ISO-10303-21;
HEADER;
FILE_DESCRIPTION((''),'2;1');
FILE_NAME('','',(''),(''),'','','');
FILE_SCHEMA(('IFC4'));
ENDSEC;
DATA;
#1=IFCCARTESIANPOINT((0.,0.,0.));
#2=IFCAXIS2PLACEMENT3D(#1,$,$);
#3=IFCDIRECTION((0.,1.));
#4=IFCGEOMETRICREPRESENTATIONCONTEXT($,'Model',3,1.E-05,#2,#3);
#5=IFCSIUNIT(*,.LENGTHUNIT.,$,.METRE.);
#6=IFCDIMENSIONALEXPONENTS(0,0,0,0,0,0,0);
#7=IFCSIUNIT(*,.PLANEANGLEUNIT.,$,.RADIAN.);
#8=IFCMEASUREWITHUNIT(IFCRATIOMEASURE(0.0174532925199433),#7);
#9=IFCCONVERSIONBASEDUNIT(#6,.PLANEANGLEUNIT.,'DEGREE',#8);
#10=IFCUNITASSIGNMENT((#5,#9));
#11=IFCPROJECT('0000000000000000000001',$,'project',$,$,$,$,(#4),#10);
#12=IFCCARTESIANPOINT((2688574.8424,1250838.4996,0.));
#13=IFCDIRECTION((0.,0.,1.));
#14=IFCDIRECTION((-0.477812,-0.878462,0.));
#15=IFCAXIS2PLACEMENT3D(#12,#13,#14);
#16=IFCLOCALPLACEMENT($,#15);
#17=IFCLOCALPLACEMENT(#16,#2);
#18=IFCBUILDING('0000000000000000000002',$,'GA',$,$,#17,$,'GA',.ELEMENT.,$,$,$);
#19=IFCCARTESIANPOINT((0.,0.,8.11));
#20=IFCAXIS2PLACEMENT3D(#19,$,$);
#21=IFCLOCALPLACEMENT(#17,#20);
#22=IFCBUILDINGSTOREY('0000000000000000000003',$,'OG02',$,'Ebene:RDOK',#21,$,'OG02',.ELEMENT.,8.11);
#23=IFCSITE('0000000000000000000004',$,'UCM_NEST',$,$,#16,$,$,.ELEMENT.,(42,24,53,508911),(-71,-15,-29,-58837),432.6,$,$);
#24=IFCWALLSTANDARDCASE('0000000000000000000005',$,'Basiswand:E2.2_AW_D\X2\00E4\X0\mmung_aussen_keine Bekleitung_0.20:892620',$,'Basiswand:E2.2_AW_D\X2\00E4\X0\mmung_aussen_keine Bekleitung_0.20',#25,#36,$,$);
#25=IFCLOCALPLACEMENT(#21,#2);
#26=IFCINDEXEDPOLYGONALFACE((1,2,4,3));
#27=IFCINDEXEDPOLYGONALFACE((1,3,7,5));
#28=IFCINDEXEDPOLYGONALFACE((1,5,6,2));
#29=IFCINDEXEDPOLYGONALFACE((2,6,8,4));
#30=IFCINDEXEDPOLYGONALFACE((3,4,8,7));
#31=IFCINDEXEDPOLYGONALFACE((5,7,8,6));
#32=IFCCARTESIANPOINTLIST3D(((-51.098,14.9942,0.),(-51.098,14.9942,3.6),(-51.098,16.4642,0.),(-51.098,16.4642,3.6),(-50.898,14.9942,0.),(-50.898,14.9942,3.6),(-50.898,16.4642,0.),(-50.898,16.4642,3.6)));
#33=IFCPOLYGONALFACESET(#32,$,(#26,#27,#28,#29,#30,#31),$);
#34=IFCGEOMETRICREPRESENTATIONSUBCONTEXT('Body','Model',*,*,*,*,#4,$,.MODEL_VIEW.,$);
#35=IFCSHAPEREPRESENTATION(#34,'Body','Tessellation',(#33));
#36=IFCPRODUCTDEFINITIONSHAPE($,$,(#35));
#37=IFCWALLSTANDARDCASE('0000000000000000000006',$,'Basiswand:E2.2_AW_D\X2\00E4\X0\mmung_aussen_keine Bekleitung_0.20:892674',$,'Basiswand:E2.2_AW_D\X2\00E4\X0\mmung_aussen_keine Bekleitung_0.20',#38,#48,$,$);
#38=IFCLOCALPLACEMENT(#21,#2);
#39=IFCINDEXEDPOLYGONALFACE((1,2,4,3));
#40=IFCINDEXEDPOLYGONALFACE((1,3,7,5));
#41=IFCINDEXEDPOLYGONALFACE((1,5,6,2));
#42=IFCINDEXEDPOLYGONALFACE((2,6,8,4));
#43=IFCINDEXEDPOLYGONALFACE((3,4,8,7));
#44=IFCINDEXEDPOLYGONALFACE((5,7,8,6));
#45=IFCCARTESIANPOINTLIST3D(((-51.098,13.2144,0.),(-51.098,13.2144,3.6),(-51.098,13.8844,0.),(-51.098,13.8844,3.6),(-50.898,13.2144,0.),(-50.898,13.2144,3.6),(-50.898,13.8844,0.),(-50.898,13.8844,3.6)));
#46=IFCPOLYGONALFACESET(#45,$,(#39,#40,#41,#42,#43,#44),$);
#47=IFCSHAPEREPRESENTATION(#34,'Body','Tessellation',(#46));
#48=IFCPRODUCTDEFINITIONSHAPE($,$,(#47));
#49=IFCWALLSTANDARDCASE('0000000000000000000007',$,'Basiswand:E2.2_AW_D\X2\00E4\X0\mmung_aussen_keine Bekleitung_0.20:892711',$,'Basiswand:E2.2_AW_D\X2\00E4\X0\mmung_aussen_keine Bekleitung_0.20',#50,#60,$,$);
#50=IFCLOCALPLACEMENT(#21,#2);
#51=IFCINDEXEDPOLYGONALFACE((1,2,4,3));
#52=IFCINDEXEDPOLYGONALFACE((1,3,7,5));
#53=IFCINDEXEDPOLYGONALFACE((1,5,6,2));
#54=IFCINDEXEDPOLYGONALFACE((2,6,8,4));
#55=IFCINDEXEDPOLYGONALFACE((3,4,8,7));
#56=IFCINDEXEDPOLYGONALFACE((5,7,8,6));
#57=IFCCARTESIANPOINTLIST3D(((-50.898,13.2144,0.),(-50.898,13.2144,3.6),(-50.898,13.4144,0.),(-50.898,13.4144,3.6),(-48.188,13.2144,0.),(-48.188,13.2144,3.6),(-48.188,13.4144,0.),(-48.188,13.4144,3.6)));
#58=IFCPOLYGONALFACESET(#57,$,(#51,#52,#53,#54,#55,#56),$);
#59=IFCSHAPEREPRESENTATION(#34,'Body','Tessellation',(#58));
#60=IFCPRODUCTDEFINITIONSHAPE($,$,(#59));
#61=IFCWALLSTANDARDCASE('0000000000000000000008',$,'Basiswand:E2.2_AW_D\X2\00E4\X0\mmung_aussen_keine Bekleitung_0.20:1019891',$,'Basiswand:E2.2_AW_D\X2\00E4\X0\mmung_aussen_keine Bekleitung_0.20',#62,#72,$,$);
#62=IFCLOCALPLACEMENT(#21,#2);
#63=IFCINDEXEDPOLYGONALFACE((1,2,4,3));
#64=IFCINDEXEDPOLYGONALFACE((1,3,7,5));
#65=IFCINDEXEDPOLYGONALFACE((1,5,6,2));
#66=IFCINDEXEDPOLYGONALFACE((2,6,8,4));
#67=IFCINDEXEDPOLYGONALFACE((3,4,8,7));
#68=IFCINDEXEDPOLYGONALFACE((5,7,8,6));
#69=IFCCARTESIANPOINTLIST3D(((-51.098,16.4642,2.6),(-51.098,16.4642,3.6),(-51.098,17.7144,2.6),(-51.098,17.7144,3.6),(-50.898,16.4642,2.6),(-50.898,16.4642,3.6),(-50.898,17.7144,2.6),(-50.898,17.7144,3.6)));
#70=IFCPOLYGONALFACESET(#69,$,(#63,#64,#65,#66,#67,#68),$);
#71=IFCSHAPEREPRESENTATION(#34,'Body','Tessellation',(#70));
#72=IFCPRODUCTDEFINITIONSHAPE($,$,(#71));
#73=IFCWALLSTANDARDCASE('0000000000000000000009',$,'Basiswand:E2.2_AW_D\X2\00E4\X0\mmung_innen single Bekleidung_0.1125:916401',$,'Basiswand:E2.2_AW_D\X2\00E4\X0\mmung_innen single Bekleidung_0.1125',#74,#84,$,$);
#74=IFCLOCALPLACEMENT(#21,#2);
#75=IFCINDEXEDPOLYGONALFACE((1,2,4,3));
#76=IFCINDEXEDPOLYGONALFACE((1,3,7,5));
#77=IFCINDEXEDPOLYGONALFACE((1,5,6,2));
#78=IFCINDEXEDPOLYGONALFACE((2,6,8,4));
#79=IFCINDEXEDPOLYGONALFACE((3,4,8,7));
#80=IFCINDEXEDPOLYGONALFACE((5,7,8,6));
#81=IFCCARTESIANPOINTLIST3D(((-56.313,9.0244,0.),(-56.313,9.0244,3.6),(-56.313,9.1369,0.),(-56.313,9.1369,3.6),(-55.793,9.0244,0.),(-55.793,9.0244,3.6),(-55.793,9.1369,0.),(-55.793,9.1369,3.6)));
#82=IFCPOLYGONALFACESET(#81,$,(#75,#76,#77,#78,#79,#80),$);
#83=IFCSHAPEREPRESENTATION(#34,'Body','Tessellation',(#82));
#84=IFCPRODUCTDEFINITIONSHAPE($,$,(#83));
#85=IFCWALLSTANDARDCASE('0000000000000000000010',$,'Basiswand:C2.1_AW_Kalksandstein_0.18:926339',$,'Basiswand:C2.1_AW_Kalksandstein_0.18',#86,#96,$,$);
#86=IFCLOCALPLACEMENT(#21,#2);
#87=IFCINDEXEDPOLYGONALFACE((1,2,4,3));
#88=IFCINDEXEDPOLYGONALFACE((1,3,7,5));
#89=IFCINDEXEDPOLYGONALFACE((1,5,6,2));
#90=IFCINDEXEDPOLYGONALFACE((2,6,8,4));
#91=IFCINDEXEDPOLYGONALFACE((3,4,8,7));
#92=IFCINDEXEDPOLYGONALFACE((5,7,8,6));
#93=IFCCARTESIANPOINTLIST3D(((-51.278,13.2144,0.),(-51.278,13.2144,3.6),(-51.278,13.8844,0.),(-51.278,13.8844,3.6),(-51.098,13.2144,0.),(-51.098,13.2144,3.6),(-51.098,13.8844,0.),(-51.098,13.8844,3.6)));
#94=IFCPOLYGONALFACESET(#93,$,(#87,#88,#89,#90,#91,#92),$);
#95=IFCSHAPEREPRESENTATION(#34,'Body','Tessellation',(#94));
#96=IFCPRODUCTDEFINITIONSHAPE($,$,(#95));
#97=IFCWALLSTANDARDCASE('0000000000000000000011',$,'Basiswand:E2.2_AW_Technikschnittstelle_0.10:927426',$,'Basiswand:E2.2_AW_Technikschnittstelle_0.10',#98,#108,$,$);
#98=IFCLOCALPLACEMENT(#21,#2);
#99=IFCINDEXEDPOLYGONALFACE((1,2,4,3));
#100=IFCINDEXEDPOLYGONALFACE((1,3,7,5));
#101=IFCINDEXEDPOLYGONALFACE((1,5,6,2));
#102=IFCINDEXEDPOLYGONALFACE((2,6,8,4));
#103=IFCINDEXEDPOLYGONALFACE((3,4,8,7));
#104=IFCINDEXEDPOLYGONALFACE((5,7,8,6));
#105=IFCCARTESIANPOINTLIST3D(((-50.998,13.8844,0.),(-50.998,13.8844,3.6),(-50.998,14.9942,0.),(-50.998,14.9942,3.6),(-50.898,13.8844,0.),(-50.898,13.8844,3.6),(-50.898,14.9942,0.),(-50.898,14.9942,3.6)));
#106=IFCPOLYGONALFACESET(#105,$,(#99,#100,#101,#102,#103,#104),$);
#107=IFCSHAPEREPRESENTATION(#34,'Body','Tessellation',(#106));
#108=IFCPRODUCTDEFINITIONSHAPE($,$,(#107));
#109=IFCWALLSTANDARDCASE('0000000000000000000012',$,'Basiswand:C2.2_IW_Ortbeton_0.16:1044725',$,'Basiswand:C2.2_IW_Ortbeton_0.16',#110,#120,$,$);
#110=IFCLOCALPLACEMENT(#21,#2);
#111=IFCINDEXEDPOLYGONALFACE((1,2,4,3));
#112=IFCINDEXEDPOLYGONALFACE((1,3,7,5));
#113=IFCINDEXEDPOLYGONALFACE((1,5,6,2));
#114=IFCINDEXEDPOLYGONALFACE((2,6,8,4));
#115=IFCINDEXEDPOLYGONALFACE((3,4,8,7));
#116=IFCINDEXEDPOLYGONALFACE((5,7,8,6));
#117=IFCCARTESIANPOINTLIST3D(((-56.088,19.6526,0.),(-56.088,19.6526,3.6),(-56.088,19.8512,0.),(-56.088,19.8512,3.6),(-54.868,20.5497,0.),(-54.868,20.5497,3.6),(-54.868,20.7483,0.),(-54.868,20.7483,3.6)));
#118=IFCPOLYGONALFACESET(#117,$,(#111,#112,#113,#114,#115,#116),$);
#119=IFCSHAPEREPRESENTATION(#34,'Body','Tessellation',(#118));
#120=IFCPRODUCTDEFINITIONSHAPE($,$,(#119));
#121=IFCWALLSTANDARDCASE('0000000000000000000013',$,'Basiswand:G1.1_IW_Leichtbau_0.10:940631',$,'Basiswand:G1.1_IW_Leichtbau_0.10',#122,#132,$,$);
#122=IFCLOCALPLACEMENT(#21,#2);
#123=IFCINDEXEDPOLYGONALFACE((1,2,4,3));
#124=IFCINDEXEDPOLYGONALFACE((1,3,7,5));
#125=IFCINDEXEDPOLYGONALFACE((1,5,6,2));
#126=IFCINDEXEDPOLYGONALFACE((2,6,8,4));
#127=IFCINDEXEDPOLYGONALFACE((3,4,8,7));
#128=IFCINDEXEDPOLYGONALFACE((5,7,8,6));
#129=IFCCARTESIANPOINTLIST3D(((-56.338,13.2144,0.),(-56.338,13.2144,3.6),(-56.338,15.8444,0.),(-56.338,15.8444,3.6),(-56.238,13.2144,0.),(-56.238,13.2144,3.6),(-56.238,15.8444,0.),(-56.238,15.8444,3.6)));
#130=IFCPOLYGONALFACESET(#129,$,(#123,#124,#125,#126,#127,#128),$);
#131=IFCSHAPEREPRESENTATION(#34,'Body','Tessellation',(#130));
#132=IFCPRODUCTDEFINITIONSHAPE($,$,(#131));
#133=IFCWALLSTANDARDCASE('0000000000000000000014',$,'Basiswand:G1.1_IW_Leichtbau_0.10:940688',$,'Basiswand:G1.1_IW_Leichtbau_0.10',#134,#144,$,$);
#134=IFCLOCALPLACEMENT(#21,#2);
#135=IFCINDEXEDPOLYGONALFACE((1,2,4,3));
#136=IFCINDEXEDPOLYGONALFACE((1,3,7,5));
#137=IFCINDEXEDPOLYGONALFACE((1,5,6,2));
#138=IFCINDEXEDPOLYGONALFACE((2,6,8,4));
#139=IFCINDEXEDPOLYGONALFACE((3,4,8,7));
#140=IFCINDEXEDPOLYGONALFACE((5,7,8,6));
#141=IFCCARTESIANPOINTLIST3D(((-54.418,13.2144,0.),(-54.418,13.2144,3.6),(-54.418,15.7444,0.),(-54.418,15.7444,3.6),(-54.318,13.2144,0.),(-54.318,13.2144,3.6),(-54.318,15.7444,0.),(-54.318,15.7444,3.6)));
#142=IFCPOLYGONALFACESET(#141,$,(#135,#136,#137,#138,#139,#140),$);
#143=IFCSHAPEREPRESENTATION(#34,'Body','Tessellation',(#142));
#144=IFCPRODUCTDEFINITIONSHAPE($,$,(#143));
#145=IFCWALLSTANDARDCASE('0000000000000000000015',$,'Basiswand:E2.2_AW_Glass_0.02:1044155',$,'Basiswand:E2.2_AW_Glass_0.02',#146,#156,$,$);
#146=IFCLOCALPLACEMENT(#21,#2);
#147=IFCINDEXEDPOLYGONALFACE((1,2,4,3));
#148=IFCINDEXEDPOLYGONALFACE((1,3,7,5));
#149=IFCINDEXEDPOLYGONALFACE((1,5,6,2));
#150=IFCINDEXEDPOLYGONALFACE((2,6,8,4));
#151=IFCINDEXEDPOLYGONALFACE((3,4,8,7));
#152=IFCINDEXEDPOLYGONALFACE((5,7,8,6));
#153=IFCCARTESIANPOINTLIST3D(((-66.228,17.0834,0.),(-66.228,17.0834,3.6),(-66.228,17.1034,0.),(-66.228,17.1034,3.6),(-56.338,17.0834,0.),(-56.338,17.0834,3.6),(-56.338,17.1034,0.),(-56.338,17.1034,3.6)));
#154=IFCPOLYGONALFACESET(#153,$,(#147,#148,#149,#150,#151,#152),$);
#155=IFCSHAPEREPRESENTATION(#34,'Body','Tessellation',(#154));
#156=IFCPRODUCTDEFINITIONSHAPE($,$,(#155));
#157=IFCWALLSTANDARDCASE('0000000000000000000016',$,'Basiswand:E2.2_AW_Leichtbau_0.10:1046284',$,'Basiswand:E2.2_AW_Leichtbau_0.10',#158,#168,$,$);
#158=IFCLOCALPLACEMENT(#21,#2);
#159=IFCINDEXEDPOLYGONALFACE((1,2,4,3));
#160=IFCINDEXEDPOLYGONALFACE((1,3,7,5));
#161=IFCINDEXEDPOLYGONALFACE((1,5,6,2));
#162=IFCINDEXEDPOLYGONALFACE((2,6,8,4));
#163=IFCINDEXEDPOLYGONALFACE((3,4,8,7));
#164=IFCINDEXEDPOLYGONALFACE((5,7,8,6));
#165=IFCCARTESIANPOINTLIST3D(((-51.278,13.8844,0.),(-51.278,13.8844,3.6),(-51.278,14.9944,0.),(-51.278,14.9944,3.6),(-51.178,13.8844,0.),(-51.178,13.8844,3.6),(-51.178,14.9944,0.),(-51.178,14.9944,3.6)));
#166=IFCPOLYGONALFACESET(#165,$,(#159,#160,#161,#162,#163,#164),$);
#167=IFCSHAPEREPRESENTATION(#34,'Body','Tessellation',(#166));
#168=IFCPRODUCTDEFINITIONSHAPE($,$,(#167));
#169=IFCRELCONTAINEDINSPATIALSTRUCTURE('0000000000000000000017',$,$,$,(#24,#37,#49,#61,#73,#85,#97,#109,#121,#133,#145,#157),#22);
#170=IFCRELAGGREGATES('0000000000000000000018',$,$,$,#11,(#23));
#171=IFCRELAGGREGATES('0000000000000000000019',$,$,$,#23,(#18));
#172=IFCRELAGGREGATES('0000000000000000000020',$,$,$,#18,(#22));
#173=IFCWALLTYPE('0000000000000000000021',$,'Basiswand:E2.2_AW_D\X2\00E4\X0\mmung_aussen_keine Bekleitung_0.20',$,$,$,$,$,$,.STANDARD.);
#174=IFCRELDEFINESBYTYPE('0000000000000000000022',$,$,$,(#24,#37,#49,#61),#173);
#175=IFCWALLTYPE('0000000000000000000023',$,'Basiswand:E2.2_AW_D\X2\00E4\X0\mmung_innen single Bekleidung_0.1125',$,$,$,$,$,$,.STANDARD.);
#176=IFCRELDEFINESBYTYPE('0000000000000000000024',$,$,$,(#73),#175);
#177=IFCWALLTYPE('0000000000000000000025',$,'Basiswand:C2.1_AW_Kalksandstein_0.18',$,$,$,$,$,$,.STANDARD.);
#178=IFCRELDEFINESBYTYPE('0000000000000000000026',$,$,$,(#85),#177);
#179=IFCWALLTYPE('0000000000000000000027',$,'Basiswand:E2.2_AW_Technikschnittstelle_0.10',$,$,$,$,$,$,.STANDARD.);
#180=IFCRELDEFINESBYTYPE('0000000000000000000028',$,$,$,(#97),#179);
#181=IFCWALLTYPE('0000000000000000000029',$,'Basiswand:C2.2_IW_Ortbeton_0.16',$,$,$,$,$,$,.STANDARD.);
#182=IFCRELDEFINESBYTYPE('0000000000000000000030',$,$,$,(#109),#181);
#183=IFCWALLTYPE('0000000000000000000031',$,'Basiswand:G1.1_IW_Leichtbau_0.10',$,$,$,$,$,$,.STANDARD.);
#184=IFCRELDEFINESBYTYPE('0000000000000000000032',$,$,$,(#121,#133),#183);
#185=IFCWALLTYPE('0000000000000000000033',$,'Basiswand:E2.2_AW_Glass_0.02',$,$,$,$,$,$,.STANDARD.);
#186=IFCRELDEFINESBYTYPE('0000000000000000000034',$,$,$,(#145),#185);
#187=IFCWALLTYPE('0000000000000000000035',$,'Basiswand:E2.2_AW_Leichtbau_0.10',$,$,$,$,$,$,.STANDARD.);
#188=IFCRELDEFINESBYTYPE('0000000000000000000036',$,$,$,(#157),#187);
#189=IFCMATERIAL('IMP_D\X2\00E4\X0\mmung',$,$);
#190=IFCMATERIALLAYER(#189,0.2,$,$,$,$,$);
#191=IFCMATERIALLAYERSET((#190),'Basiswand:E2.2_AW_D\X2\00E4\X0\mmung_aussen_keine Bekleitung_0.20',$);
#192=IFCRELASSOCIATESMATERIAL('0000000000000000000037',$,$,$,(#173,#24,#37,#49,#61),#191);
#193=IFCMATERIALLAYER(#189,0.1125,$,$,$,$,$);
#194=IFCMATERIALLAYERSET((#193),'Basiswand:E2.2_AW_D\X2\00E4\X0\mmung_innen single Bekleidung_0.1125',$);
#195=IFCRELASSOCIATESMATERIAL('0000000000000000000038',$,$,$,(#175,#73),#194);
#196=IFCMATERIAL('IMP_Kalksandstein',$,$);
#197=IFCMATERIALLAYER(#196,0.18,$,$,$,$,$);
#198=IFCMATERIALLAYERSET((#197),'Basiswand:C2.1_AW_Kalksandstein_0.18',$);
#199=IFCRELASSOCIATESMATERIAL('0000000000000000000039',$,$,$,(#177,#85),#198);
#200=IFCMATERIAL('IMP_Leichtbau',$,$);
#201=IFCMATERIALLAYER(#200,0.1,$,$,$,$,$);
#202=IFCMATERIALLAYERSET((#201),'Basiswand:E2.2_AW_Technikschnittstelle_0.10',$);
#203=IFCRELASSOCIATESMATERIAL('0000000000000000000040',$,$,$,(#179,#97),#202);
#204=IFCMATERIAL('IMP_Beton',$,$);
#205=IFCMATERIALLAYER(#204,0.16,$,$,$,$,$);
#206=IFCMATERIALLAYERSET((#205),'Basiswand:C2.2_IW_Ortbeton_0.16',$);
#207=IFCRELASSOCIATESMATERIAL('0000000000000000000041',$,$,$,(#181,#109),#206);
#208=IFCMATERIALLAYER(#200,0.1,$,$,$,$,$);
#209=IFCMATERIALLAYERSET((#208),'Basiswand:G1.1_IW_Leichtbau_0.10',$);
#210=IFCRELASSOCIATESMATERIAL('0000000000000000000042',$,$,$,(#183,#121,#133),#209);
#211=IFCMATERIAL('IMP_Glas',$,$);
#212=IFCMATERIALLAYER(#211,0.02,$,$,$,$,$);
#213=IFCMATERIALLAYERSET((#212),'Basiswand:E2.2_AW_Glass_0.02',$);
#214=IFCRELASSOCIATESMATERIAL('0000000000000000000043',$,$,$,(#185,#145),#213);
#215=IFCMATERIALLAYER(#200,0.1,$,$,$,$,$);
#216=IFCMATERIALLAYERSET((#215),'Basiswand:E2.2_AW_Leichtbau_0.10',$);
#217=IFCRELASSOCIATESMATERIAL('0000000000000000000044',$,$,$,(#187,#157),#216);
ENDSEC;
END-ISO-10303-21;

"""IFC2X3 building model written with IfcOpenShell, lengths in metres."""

from ifc_helpers import new_model, entity, si_unit, converted_unit, direction, frame, frame_2d, origin, place, context, subcontext, project, spatial, polyline, rectangle, outline, extrude, material, layer, layer_set, layer_usage, type_object, element, save


model = new_model("IFC2X3")

# Units and contexts
model_context = context("Model", 3, precision=1e-05, world=origin(), true_north=direction((0.0, 1.0)))
body_context = subcontext(model_context, "Body", "Model", "MODEL_VIEW")
ifc_project = project(units=[si_unit("LENGTHUNIT", "METRE"), converted_unit("PLANEANGLEUNIT", "DEGREE", entity("IfcRatioMeasure", 0.0174532925199433), si_unit("PLANEANGLEUNIT", "RADIAN"), dimensions=[0, 0, 0, 0, 0, 0, 0])], contexts=[model_context])

# Site, building, storey
site_placement = place(None, frame((2688574.8424, 1250838.4996, 0.0), z_axis=(0.0, 0.0, 1.0), x_axis=(-0.477812, -0.878462, 0.0)))
site = spatial("IfcSite", under=ifc_project, at=site_placement, Name="UCM_NEST", CompositionType="ELEMENT", RefLatitude=(42, 24, 53, 508911), RefLongitude=(-71, -15, -29, -58837), RefElevation=432.6)
building_placement = place(site_placement, origin())
building = spatial("IfcBuilding", under=site, at=building_placement, Name="GA", LongName="GA", CompositionType="ELEMENT")
storey_placement = place(building_placement, frame((0.0, 0.0, 8.11)))
storey = spatial("IfcBuildingStorey", under=building, at=storey_placement, Name="OG02", ObjectType="Ebene:RDOK", LongName="OG02", CompositionType="ELEMENT", Elevation=8.11)

# Walls
ifc_material_1 = material(Name="IMP_Dämmung")
ifc_layer_1 = layer(ifc_material_1, 0.2)
ifc_layer_set_1 = layer_set([ifc_layer_1], Name="Basiswand:E2.2_AW_Dämmung_aussen_keine Bekleitung_0.20")
ifc_layer_usage_1 = layer_usage(ifc_layer_set_1, "AXIS2", "NEGATIVE", 0.1)
wall_type_1 = type_object("IfcWallType", Name="Basiswand:E2.2_AW_Dämmung_aussen_keine Bekleitung_0.20", PredefinedType="STANDARD", material=ifc_layer_set_1)
wall_1_placement = place(storey_placement, frame((-50.998, 16.4642, 0.0), z_axis=(0.0, 0.0, 1.0), x_axis=(0.0, -1.0, 0.0)))
element("IfcWallStandardCase", 1, at=wall_1_placement, inside=storey, type_object=wall_type_1, material=ifc_layer_usage_1, Name="Basiswand:E2.2_AW_Dämmung_aussen_keine Bekleitung_0.20:892620", ObjectType="Basiswand:E2.2_AW_Dämmung_aussen_keine Bekleitung_0.20", context=body_context, shape_type="SweptSolid", body=[
    extrude(rectangle(XDim=1.47, YDim=0.2, at=frame_2d((0.735, 0.0), x_axis=(-1.0, 0.0))), origin(), (0.0, 0.0, 1.0), 3.6),
])
ifc_layer_usage_2 = layer_usage(ifc_layer_set_1, "AXIS2", "NEGATIVE", 0.1)
wall_2_placement = place(storey_placement, frame((-50.998, 13.8844, 0.0), z_axis=(0.0, 0.0, 1.0), x_axis=(0.0, -1.0, 0.0)))
element("IfcWallStandardCase", 2, at=wall_2_placement, inside=storey, type_object=wall_type_1, material=ifc_layer_usage_2, Name="Basiswand:E2.2_AW_Dämmung_aussen_keine Bekleitung_0.20:892674", ObjectType="Basiswand:E2.2_AW_Dämmung_aussen_keine Bekleitung_0.20", context=body_context, shape_type="SweptSolid", body=[
    extrude(rectangle(XDim=0.67, YDim=0.2, at=frame_2d((0.335, 0.0), x_axis=(-1.0, 0.0))), origin(), (0.0, 0.0, 1.0), 3.6),
])
ifc_layer_usage_3 = layer_usage(ifc_layer_set_1, "AXIS2", "NEGATIVE", 0.1)
wall_3_placement = place(storey_placement, frame((-50.898, 13.3144, 0.0)))
element("IfcWallStandardCase", 3, at=wall_3_placement, inside=storey, type_object=wall_type_1, material=ifc_layer_usage_3, Name="Basiswand:E2.2_AW_Dämmung_aussen_keine Bekleitung_0.20:892711", ObjectType="Basiswand:E2.2_AW_Dämmung_aussen_keine Bekleitung_0.20", context=body_context, shape_type="SweptSolid", body=[
    extrude(rectangle(XDim=2.71, YDim=0.2, at=frame_2d((1.355, 0.0), x_axis=(-1.0, 0.0))), origin(), (0.0, 0.0, 1.0), 3.6),
])
ifc_layer_usage_4 = layer_usage(ifc_layer_set_1, "AXIS2", "NEGATIVE", 0.1)
wall_4_placement = place(storey_placement, frame((-50.998, 17.7144, 2.6), z_axis=(0.0, 0.0, 1.0), x_axis=(0.0, -1.0, 0.0)))
element("IfcWallStandardCase", 4, at=wall_4_placement, inside=storey, type_object=wall_type_1, material=ifc_layer_usage_4, Name="Basiswand:E2.2_AW_Dämmung_aussen_keine Bekleitung_0.20:1019891", ObjectType="Basiswand:E2.2_AW_Dämmung_aussen_keine Bekleitung_0.20", context=body_context, shape_type="SweptSolid", body=[
    extrude(rectangle(XDim=1.2502, YDim=0.2, at=frame_2d((0.6251, 0.0), x_axis=(-1.0, 0.0))), origin(), (0.0, 0.0, 1.0), 1.0),
])

# Shared definitions
ifc_material_2 = material(Name="IMP_Beton")

# Walls
ifc_layer_2 = layer(ifc_material_1, 0.1125)
ifc_layer_set_2 = layer_set([ifc_layer_2], Name="Basiswand:E2.2_AW_Dämmung_innen single Bekleidung_0.1125")
ifc_layer_usage_5 = layer_usage(ifc_layer_set_2, "AXIS2", "NEGATIVE", 0.0563)
wall_type_2 = type_object("IfcWallType", Name="Basiswand:E2.2_AW_Dämmung_innen single Bekleidung_0.1125", PredefinedType="STANDARD", material=ifc_layer_set_2)
wall_5_placement = place(storey_placement, frame((-56.313, 9.0807, 0.0)))
element("IfcWallStandardCase", 5, at=wall_5_placement, inside=storey, type_object=wall_type_2, material=ifc_layer_usage_5, Name="Basiswand:E2.2_AW_Dämmung_innen single Bekleidung_0.1125:916401", ObjectType="Basiswand:E2.2_AW_Dämmung_innen single Bekleidung_0.1125", context=body_context, shape_type="SweptSolid", body=[
    extrude(rectangle(XDim=0.52, YDim=0.1125, at=frame_2d((0.26, 0.0), x_axis=(-1.0, 0.0))), origin(), (0.0, 0.0, 1.0), 3.6),
])
ifc_material_3 = material(Name="IMP_Kalksandstein")
ifc_layer_3 = layer(ifc_material_3, 0.18)
ifc_layer_set_3 = layer_set([ifc_layer_3], Name="Basiswand:C2.1_AW_Kalksandstein_0.18")
ifc_layer_usage_6 = layer_usage(ifc_layer_set_3, "AXIS2", "NEGATIVE", 0.09)
wall_type_3 = type_object("IfcWallType", Name="Basiswand:C2.1_AW_Kalksandstein_0.18", PredefinedType="STANDARD", material=ifc_layer_set_3)
wall_6_placement = place(storey_placement, frame((-51.188, 13.8844, 0.0), z_axis=(0.0, 0.0, 1.0), x_axis=(0.0, -1.0, 0.0)))
element("IfcWallStandardCase", 6, at=wall_6_placement, inside=storey, type_object=wall_type_3, material=ifc_layer_usage_6, Name="Basiswand:C2.1_AW_Kalksandstein_0.18:926339", ObjectType="Basiswand:C2.1_AW_Kalksandstein_0.18", context=body_context, shape_type="SweptSolid", body=[
    extrude(rectangle(XDim=0.67, YDim=0.18, at=frame_2d((0.335, 0.0), x_axis=(-1.0, 0.0))), origin(), (0.0, 0.0, 1.0), 3.6),
])
ifc_material_4 = material(Name="IMP_Leichtbau")
ifc_layer_4 = layer(ifc_material_4, 0.1)
ifc_layer_set_4 = layer_set([ifc_layer_4], Name="Basiswand:E2.2_AW_Technikschnittstelle_0.10")
ifc_layer_usage_7 = layer_usage(ifc_layer_set_4, "AXIS2", "NEGATIVE", 0.05)
wall_type_4 = type_object("IfcWallType", Name="Basiswand:E2.2_AW_Technikschnittstelle_0.10", PredefinedType="STANDARD", material=ifc_layer_set_4)
wall_7_placement = place(storey_placement, frame((-50.948, 14.9942, 0.0), z_axis=(0.0, 0.0, 1.0), x_axis=(0.0, -1.0, 0.0)))
element("IfcWallStandardCase", 7, at=wall_7_placement, inside=storey, type_object=wall_type_4, material=ifc_layer_usage_7, Name="Basiswand:E2.2_AW_Technikschnittstelle_0.10:927426", ObjectType="Basiswand:E2.2_AW_Technikschnittstelle_0.10", context=body_context, shape_type="SweptSolid", body=[
    extrude(rectangle(XDim=1.1098, YDim=0.1, at=frame_2d((0.5549, 0.0), x_axis=(-1.0, 0.0))), origin(), (0.0, 0.0, 1.0), 3.6),
])
ifc_layer_5 = layer(ifc_material_2, 0.16)
ifc_layer_set_5 = layer_set([ifc_layer_5], Name="Basiswand:C2.2_IW_Ortbeton_0.16")
wall_type_5 = type_object("IfcWallType", Name="Basiswand:C2.2_IW_Ortbeton_0.16", PredefinedType="STANDARD", material=ifc_layer_set_5)
ifc_layer_usage_8 = layer_usage(ifc_layer_set_5, "AXIS2", "NEGATIVE", 0.08)
wall_8_placement = place(storey_placement, frame((-54.8206, 20.6838, 0.0), z_axis=(0.0, 0.0, 1.0), x_axis=(-0.805651, -0.59239, 0.0)))
element("IfcWallStandardCase", 8, at=wall_8_placement, inside=storey, type_object=wall_type_5, material=ifc_layer_usage_8, Name="Basiswand:C2.2_IW_Ortbeton_0.16:1044725", ObjectType="Basiswand:C2.2_IW_Ortbeton_0.16", context=body_context, shape_type="SweptSolid", body=[
    extrude(outline(polyline([(1.5143, -0.08), (1.632, 0.08), (0.1176, 0.08), (0.0, -0.08), (1.5143, -0.08)])), origin(), (0.0, 0.0, 1.0), 3.6),
])
ifc_layer_6 = layer(ifc_material_4, 0.1)
ifc_layer_set_6 = layer_set([ifc_layer_6], Name="Basiswand:G1.1_IW_Leichtbau_0.10")
ifc_layer_usage_9 = layer_usage(ifc_layer_set_6, "AXIS2", "NEGATIVE", 0.05)
wall_type_6 = type_object("IfcWallType", Name="Basiswand:G1.1_IW_Leichtbau_0.10", PredefinedType="STANDARD", material=ifc_layer_set_6)
wall_9_placement = place(storey_placement, frame((-56.288, 15.8444, 0.0), z_axis=(0.0, 0.0, 1.0), x_axis=(0.0, -1.0, 0.0)))
element("IfcWallStandardCase", 9, at=wall_9_placement, inside=storey, type_object=wall_type_6, material=ifc_layer_usage_9, Name="Basiswand:G1.1_IW_Leichtbau_0.10:940631", ObjectType="Basiswand:G1.1_IW_Leichtbau_0.10", context=body_context, shape_type="SweptSolid", body=[
    extrude(rectangle(XDim=2.63, YDim=0.1, at=frame_2d((1.315, 0.0), x_axis=(-1.0, 0.0))), origin(), (0.0, 0.0, 1.0), 3.6),
])
ifc_layer_usage_10 = layer_usage(ifc_layer_set_6, "AXIS2", "NEGATIVE", 0.05)
wall_10_placement = place(storey_placement, frame((-54.368, 13.2144, 0.0), z_axis=(0.0, 0.0, 1.0), x_axis=(0.0, 1.0, 0.0)))
element("IfcWallStandardCase", 10, at=wall_10_placement, inside=storey, type_object=wall_type_6, material=ifc_layer_usage_10, Name="Basiswand:G1.1_IW_Leichtbau_0.10:940688", ObjectType="Basiswand:G1.1_IW_Leichtbau_0.10", context=body_context, shape_type="SweptSolid", body=[
    extrude(rectangle(XDim=2.53, YDim=0.1, at=frame_2d((1.265, 0.0), x_axis=(-1.0, 0.0))), origin(), (0.0, 0.0, 1.0), 3.6),
])

# Walls
ifc_material_5 = material(Name="IMP_Glas")
ifc_layer_7 = layer(ifc_material_5, 0.02)
ifc_layer_set_7 = layer_set([ifc_layer_7], Name="Basiswand:E2.2_AW_Glass_0.02")
ifc_layer_usage_11 = layer_usage(ifc_layer_set_7, "AXIS2", "NEGATIVE", 0.01)
wall_type_7 = type_object("IfcWallType", Name="Basiswand:E2.2_AW_Glass_0.02", PredefinedType="STANDARD", material=ifc_layer_set_7)
wall_11_placement = place(storey_placement, frame((-56.338, 17.0934, 0.0), z_axis=(0.0, 0.0, 1.0), x_axis=(-1.0, 0.0, 0.0)))
element("IfcWallStandardCase", 11, at=wall_11_placement, inside=storey, type_object=wall_type_7, material=ifc_layer_usage_11, Name="Basiswand:E2.2_AW_Glass_0.02:1044155", ObjectType="Basiswand:E2.2_AW_Glass_0.02", context=body_context, shape_type="SweptSolid", body=[
    extrude(rectangle(XDim=9.89, YDim=0.02, at=frame_2d((4.945, 0.0), x_axis=(-1.0, 0.0))), origin(), (0.0, 0.0, 1.0), 3.6),
])
ifc_layer_8 = layer(ifc_material_4, 0.1)
ifc_layer_set_8 = layer_set([ifc_layer_8], Name="Basiswand:E2.2_AW_Leichtbau_0.10")
ifc_layer_usage_12 = layer_usage(ifc_layer_set_8, "AXIS2", "NEGATIVE", 0.05)
wall_type_8 = type_object("IfcWallType", Name="Basiswand:E2.2_AW_Leichtbau_0.10", PredefinedType="STANDARD", material=ifc_layer_set_8)
wall_12_placement = place(storey_placement, frame((-51.228, 13.8844, 0.0), z_axis=(0.0, 0.0, 1.0), x_axis=(0.0, 1.0, 0.0)))
element("IfcWallStandardCase", 12, at=wall_12_placement, inside=storey, type_object=wall_type_8, material=ifc_layer_usage_12, Name="Basiswand:E2.2_AW_Leichtbau_0.10:1046284", ObjectType="Basiswand:E2.2_AW_Leichtbau_0.10", context=body_context, shape_type="SweptSolid", body=[
    extrude(rectangle(XDim=1.11, YDim=0.1, at=frame_2d((0.555, 0.0), x_axis=(-1.0, 0.0))), origin(), (0.0, 0.0, 1.0), 3.6),
])

save(model, "model.ifc")
